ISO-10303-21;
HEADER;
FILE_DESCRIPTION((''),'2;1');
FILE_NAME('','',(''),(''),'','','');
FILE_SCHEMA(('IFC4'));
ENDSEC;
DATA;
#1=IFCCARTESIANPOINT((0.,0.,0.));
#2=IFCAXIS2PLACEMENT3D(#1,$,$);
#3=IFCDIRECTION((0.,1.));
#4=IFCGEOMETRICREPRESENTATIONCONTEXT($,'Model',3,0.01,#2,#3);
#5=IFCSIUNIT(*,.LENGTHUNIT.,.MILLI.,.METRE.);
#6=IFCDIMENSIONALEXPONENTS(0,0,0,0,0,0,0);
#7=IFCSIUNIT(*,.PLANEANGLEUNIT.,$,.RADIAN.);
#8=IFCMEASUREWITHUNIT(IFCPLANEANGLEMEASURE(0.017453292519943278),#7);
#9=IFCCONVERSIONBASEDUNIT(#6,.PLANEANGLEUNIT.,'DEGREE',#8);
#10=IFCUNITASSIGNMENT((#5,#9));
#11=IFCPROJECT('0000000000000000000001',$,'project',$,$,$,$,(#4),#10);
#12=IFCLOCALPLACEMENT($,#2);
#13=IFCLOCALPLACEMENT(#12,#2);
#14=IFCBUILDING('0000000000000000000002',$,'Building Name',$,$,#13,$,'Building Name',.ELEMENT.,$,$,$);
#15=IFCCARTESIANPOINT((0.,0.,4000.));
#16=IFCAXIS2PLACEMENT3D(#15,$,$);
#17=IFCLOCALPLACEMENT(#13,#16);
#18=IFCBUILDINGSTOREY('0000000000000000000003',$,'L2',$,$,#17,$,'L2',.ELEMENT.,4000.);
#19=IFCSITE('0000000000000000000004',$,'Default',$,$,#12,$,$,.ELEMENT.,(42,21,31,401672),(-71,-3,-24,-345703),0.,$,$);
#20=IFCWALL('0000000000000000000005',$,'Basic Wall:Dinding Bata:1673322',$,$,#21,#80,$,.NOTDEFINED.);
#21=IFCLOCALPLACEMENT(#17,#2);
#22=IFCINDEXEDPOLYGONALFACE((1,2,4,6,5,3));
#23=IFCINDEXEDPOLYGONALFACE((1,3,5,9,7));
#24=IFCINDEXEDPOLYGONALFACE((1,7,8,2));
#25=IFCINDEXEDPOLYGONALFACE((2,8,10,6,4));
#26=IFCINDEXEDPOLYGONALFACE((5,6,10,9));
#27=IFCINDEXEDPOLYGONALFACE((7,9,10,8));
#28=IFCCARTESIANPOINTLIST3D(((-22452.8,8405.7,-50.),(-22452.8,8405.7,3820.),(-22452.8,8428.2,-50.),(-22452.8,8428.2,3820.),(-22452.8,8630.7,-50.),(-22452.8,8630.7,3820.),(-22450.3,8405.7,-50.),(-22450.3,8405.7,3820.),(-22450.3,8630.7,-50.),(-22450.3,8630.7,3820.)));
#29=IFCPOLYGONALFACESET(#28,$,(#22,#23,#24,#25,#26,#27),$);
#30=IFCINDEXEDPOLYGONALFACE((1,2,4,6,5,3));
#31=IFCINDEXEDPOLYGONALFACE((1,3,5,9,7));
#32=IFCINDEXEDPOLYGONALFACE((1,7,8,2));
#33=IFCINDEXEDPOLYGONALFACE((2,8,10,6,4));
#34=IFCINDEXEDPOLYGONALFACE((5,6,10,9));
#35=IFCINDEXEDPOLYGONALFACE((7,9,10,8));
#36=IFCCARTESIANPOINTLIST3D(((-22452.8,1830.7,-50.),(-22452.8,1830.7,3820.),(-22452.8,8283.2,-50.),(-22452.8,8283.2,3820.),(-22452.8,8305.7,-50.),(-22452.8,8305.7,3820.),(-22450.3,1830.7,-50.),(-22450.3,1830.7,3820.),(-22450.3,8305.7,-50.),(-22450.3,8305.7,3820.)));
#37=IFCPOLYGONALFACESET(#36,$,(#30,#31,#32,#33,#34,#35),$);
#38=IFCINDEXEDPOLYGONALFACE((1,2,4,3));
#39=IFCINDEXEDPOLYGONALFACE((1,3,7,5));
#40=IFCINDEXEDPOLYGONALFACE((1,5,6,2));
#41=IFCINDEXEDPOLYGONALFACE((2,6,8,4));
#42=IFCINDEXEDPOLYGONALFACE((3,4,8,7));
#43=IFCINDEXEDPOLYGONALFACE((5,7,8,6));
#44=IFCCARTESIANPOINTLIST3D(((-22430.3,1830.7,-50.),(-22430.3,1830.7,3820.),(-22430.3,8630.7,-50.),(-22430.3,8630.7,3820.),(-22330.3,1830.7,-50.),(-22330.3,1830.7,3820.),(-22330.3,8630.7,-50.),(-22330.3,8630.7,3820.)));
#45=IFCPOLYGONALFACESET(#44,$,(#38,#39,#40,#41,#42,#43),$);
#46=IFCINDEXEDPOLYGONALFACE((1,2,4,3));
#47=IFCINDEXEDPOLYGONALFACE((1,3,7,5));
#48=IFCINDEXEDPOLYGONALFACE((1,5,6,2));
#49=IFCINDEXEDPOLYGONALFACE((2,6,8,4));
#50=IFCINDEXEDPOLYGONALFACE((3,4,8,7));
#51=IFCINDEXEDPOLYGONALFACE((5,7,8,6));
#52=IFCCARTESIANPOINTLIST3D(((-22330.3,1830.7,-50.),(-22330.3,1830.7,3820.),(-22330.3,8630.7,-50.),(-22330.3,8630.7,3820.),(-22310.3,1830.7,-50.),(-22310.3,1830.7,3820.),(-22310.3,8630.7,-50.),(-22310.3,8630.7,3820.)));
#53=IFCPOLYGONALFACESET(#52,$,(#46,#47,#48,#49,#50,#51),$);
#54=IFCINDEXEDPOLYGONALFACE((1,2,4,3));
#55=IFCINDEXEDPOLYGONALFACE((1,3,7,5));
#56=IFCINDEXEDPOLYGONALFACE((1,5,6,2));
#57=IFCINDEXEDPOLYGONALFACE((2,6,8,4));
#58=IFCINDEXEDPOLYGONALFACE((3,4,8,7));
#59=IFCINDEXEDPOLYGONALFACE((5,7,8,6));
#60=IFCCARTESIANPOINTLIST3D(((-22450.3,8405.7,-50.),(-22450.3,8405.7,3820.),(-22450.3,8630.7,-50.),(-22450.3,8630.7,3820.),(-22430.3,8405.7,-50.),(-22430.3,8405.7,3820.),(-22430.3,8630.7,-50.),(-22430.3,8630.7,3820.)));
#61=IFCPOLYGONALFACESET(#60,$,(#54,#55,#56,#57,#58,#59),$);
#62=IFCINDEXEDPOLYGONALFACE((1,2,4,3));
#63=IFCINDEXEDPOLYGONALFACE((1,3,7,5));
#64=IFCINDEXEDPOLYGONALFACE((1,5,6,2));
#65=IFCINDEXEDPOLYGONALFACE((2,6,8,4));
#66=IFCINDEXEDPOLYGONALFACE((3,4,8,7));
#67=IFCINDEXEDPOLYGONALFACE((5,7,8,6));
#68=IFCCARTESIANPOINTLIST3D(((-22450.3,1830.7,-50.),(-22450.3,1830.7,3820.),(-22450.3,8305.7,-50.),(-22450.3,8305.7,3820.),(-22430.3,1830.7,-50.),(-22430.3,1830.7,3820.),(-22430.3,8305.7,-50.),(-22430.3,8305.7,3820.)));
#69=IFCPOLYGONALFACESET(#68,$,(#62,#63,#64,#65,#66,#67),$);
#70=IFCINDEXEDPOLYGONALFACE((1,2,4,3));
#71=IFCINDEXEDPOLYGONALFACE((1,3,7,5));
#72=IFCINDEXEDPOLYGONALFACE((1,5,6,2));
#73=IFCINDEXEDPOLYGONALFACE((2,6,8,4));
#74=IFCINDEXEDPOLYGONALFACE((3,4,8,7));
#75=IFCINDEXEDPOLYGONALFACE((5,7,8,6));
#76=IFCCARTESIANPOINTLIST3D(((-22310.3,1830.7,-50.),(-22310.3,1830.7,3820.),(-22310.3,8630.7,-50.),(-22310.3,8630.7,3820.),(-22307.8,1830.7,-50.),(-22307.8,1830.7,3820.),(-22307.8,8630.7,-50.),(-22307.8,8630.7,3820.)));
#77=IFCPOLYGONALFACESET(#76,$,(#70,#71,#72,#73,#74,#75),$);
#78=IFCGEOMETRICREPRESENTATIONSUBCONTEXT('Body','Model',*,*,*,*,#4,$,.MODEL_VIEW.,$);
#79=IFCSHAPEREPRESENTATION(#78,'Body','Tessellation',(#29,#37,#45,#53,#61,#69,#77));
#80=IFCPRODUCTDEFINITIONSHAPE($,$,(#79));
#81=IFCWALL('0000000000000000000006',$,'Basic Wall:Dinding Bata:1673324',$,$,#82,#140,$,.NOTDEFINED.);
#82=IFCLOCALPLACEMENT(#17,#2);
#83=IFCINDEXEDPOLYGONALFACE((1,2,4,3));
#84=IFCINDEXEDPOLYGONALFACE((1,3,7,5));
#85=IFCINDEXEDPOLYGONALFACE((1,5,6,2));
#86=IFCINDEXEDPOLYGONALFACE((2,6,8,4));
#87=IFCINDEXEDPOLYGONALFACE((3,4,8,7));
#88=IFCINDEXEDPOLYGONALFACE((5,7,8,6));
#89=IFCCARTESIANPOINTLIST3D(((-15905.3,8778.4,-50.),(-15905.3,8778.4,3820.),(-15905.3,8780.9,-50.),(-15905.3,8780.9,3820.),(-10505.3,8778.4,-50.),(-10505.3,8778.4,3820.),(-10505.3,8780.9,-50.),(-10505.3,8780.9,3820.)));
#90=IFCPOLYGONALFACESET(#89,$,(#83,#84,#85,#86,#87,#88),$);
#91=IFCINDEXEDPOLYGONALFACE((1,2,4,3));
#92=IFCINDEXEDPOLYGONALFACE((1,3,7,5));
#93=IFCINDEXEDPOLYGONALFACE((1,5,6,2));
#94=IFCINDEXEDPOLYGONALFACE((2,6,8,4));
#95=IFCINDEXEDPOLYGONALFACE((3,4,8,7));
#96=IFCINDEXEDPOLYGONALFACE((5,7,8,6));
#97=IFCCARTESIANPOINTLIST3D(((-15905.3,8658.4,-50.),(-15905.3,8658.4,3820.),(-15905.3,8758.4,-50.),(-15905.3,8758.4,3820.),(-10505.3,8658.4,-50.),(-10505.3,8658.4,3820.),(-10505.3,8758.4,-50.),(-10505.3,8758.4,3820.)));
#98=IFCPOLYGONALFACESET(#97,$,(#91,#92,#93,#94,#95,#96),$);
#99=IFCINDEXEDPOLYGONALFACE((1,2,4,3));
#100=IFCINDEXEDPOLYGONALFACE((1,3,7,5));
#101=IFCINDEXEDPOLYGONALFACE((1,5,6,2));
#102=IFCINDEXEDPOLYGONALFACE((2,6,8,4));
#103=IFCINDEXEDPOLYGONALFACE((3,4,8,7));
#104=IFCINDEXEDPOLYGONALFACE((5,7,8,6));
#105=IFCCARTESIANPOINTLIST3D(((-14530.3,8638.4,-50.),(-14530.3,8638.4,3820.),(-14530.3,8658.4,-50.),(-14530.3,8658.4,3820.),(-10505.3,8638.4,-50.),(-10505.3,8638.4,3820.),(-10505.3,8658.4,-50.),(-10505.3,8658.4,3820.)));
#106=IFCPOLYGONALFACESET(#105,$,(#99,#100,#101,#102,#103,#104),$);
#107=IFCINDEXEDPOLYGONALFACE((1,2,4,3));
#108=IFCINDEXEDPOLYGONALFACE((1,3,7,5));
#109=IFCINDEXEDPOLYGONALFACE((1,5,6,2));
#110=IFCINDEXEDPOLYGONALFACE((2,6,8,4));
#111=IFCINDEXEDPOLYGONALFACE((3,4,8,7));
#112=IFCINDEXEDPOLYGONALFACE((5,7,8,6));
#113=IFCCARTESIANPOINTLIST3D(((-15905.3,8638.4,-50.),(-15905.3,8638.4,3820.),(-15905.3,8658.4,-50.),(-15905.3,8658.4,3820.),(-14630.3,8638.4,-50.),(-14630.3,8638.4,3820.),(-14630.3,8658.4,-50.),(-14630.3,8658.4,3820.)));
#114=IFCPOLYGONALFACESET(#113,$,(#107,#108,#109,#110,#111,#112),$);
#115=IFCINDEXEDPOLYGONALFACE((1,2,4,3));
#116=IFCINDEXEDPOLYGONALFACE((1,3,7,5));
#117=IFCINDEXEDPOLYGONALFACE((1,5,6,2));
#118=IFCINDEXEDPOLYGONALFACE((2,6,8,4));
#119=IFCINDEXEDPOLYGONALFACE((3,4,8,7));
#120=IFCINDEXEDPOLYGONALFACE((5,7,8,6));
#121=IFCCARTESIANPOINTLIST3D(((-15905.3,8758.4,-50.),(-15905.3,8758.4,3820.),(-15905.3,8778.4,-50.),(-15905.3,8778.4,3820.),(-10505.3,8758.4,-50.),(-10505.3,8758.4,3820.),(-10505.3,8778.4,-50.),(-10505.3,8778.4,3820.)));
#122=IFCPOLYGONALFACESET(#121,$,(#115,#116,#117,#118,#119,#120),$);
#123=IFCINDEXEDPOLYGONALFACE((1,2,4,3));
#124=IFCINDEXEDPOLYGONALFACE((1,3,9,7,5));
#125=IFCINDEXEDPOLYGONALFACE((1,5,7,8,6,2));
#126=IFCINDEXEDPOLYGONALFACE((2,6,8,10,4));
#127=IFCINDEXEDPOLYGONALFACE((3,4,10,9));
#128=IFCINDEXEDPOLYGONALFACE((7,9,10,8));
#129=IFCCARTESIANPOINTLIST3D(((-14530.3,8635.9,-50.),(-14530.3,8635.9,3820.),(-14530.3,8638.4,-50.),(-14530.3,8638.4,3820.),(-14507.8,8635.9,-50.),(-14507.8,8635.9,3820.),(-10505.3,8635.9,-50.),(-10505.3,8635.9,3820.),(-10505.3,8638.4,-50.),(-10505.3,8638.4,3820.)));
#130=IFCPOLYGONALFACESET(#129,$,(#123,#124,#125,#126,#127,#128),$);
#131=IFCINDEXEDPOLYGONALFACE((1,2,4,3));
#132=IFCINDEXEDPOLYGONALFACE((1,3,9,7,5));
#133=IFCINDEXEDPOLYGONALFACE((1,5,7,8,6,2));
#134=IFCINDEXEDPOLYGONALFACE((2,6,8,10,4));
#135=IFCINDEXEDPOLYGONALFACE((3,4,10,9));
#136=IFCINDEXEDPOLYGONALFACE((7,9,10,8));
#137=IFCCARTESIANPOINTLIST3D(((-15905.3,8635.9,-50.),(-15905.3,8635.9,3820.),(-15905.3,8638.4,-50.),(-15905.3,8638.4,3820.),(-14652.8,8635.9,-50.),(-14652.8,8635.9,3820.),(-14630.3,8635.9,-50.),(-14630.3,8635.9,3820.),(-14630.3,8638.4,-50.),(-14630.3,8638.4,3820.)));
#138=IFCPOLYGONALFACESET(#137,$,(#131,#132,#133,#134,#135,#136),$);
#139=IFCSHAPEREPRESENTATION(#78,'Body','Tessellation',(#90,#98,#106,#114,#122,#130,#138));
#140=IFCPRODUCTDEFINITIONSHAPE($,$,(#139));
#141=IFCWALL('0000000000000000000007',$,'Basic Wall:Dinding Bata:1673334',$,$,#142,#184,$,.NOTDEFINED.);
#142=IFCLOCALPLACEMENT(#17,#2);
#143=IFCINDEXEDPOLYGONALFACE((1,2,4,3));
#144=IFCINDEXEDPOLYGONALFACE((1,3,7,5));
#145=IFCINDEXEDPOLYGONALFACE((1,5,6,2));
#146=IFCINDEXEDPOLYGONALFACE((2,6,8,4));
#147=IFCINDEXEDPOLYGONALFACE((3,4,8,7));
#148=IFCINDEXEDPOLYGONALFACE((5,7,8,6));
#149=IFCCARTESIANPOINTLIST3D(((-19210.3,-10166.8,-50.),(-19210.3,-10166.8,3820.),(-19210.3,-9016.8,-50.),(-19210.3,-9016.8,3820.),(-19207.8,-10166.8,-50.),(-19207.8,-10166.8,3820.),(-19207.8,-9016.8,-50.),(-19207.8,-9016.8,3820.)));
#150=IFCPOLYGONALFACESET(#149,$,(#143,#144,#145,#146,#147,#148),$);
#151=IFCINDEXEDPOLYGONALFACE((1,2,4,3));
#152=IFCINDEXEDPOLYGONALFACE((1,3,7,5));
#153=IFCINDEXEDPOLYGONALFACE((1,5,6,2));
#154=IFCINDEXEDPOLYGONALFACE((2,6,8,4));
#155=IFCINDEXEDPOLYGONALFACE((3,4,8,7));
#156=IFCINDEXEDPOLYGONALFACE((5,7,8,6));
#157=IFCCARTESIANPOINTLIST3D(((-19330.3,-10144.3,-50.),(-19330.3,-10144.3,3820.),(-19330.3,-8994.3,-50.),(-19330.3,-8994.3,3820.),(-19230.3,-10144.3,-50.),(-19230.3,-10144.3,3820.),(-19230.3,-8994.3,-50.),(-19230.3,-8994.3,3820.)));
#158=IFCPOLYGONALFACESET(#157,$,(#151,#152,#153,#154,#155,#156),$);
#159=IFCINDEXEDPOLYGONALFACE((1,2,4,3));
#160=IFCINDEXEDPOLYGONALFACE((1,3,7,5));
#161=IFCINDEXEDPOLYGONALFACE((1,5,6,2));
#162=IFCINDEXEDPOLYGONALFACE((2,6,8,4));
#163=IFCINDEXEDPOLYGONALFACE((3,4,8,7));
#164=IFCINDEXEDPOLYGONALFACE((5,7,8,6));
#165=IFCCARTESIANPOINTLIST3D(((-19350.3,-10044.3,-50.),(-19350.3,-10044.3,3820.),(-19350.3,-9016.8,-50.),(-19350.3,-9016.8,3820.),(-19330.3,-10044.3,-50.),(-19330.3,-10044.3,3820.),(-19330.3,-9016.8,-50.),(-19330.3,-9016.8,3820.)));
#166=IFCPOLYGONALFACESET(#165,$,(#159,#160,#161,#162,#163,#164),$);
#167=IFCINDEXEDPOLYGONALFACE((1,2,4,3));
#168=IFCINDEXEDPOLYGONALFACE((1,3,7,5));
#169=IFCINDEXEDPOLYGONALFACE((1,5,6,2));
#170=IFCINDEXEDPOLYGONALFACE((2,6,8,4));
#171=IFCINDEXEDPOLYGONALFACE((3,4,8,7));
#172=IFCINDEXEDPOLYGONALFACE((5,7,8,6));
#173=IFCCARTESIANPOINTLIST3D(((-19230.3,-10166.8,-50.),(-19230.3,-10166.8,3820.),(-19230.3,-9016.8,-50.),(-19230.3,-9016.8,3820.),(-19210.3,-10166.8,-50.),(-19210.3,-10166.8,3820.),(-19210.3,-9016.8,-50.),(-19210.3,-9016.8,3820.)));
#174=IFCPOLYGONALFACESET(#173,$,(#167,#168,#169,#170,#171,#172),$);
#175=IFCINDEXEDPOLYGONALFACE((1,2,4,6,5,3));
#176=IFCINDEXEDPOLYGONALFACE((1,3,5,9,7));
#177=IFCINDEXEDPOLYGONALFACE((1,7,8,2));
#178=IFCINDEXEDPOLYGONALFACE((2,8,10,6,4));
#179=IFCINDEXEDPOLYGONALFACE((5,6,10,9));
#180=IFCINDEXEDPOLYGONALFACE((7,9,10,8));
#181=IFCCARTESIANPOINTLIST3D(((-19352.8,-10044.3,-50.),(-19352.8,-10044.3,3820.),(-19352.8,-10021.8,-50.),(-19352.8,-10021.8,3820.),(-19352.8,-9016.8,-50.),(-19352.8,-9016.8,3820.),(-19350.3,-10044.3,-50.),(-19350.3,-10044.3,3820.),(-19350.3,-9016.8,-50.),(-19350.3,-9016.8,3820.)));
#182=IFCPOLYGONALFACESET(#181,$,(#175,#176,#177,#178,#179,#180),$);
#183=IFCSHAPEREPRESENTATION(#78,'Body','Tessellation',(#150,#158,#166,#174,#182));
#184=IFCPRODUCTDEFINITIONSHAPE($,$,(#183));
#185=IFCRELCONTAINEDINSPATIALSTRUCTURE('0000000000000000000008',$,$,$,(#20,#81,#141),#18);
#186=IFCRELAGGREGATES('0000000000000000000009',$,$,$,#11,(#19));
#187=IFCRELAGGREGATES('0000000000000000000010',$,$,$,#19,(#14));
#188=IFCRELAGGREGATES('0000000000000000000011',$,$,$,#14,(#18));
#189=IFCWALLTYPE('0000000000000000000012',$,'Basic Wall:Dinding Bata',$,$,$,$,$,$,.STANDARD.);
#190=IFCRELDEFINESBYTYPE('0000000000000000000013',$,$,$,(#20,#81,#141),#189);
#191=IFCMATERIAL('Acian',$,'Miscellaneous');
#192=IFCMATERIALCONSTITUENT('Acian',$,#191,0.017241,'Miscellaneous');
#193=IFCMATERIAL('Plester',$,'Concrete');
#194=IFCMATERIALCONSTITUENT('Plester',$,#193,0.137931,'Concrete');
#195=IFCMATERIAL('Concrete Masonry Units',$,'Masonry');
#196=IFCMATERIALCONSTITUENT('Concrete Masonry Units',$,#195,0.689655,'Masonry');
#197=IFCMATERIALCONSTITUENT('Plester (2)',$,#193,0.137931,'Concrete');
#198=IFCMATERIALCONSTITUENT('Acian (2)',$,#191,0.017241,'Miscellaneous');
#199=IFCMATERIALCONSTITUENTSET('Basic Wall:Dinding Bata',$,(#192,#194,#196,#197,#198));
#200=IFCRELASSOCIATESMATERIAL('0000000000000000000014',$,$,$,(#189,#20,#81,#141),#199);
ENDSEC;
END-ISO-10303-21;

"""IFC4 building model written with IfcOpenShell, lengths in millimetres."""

from ifc_helpers import new_model, entity, si_unit, converted_unit, direction, frame, origin, place, context, subcontext, project, spatial, indexed_curve, outline, extrude, material, constituent, constituent_set, type_object, element, save


model = new_model("IFC4")

# Units and contexts
model_context = context("Model", 3, precision=0.01, world=origin(), true_north=direction((0.0, 1.0)))
body_context = subcontext(model_context, "Body", "Model", "MODEL_VIEW")
ifc_project = project(units=[si_unit("LENGTHUNIT", "METRE", prefix="MILLI"), converted_unit("PLANEANGLEUNIT", "DEGREE", entity("IfcPlaneAngleMeasure", 0.017453292519943278), si_unit("PLANEANGLEUNIT", "RADIAN"), dimensions=[0, 0, 0, 0, 0, 0, 0])], contexts=[model_context])

# Site, building, storey
site_placement = place(None, origin())
site = spatial("IfcSite", under=ifc_project, at=site_placement, Name="Default", CompositionType="ELEMENT", RefLatitude=(42, 21, 31, 401672), RefLongitude=(-71, -3, -24, -345703), RefElevation=0.0)
building_placement = place(site_placement, origin())
building = spatial("IfcBuilding", under=site, at=building_placement, Name="Building Name", LongName="Building Name", CompositionType="ELEMENT")
storey_placement = place(building_placement, frame((0.0, 0.0, 4000.0)))
storey = spatial("IfcBuildingStorey", under=building, at=storey_placement, Name="L2", LongName="L2", CompositionType="ELEMENT", Elevation=4000.0)

# Walls
ifc_material_1 = material(Name="Acian", Category="Miscellaneous")
ifc_constituent_1 = constituent(ifc_material_1, Name="Acian", Category="Miscellaneous", fraction=0.017241)
ifc_material_2 = material(Name="Plester", Category="Concrete")
ifc_constituent_2 = constituent(ifc_material_2, Name="Plester", Category="Concrete", fraction=0.137931)
ifc_material_3 = material(Name="Concrete Masonry Units", Category="Masonry")
ifc_constituent_3 = constituent(ifc_material_3, Name="Concrete Masonry Units", Category="Masonry", fraction=0.689655)
ifc_constituent_4 = constituent(ifc_material_2, Name="Plester (2)", Category="Concrete", fraction=0.137931)
ifc_constituent_5 = constituent(ifc_material_1, Name="Acian (2)", Category="Miscellaneous", fraction=0.017241)
ifc_constituent_set = constituent_set(constituents=[ifc_constituent_1, ifc_constituent_2, ifc_constituent_3, ifc_constituent_4, ifc_constituent_5], Name="Basic Wall:Dinding Bata")
wall_type = type_object("IfcWallType", Name="Basic Wall:Dinding Bata", PredefinedType="STANDARD", material=ifc_constituent_set)
wall_1_placement = place(storey_placement, frame((-22380.3, 1830.7, -50.0), z_axis=(0.0, 0.0, 1.0), x_axis=(0.0, 1.0, 0.0)))
element("IfcWall", 1, at=wall_1_placement, inside=storey, type_object=wall_type, material=ifc_constituent_set, Name="Basic Wall:Dinding Bata:1673322", PredefinedType="NOTDEFINED", context=body_context, shape_type="SweptSolid", body=[
    extrude(outline(indexed_curve([(72.0, -1.0), (94.5, -1.0), (94.5, 1.5), (-130.5, 1.5), (-130.5, -1.0), (72.0, -1.0)], self_intersect=False)), frame((6669.5, 71.5, 0.0), z_axis=(0.0, 0.0, 1.0), x_axis=(-1.0, 0.0, 0.0)), (0.0, 0.0, 1.0), 3870.0),
    extrude(outline(indexed_curve([(-3880.5, -1.5), (2594.5, -1.5), (2594.5, 1.0), (2572.0, 1.0), (-3880.5, 1.0), (-3880.5, -1.5)], self_intersect=False)), frame((3880.5, 71.5, 0.0)), (0.0, 0.0, 1.0), 3870.0),
    extrude(outline(indexed_curve([(-3400.0, -50.0), (3400.0, -50.0), (3400.0, 50.0), (-3400.0, 50.0), (-3400.0, -50.0)], self_intersect=False)), frame((3400.0, 0.0, 0.0)), (0.0, 0.0, 1.0), 3870.0),
    extrude(outline(indexed_curve([(-3400.0, -10.0), (3400.0, -10.0), (3400.0, 10.0), (-3400.0, 10.0), (-3400.0, -10.0)], self_intersect=False)), frame((3400.0, -60.0, 0.0)), (0.0, 0.0, 1.0), 3870.0),
    extrude(outline(indexed_curve([(-112.5, -10.0), (112.5, -10.0), (112.5, 10.0), (-112.5, 10.0), (-112.5, -10.0)], self_intersect=False)), frame((6687.5, 60.0, 0.0), z_axis=(0.0, 0.0, 1.0), x_axis=(-1.0, 0.0, 0.0)), (0.0, 0.0, 1.0), 3870.0),
    extrude(outline(indexed_curve([(-3237.5, -10.0), (3237.5, -10.0), (3237.5, 10.0), (-3237.5, 10.0), (-3237.5, -10.0)], self_intersect=False)), frame((3237.5, 60.0, 0.0)), (0.0, 0.0, 1.0), 3870.0),
    extrude(outline(indexed_curve([(-1.3, -3400.0), (1.2, -3400.0), (1.3, 3400.0), (-1.2, 3400.0), (-1.3, -3400.0)], self_intersect=False)), frame((3400.0, -71.3, 0.0), z_axis=(0.0, 0.0, 1.0), x_axis=(0.0, 1.0, 0.0)), (0.0, 0.0, 1.0), 3870.0),
])
wall_2_placement = place(storey_placement, frame((-15905.3, 8708.4, -50.0)))
element("IfcWall", 2, at=wall_2_placement, inside=storey, type_object=wall_type, material=ifc_constituent_set, Name="Basic Wall:Dinding Bata:1673324", PredefinedType="NOTDEFINED", context=body_context, shape_type="SweptSolid", body=[
    extrude(outline(indexed_curve([(-1.3, -2700.0), (1.2, -2700.0), (1.3, 2700.0), (-1.2, 2700.0), (-1.3, -2700.0)], self_intersect=False)), frame((2700.0, 71.3, 0.0), z_axis=(0.0, 0.0, 1.0), x_axis=(0.0, -1.0, 0.0)), (0.0, 0.0, 1.0), 3870.0),
    extrude(outline(indexed_curve([(-2700.0, -50.0), (2700.0, -50.0), (2700.0, 50.0), (-2700.0, 50.0), (-2700.0, -50.0)], self_intersect=False)), frame((2700.0, 0.0, 0.0)), (0.0, 0.0, 1.0), 3870.0),
    extrude(outline(indexed_curve([(-2012.5, -10.0), (2012.5, -10.0), (2012.5, 10.0), (-2012.5, 10.0), (-2012.5, -10.0)], self_intersect=False)), frame((3387.5, -60.0, 0.0), z_axis=(0.0, 0.0, 1.0), x_axis=(-1.0, 0.0, 0.0)), (0.0, 0.0, 1.0), 3870.0),
    extrude(outline(indexed_curve([(-637.5, -10.0), (637.5, -10.0), (637.5, 10.0), (-637.5, 10.0), (-637.5, -10.0)], self_intersect=False)), frame((637.5, -60.0, 0.0)), (0.0, 0.0, 1.0), 3870.0),
    extrude(outline(indexed_curve([(-2700.0, -10.0), (2700.0, -10.0), (2700.0, 10.0), (-2700.0, 10.0), (-2700.0, -10.0)], self_intersect=False)), frame((2700.0, 60.0, 0.0)), (0.0, 0.0, 1.0), 3870.0),
    extrude(outline(indexed_curve([(-1.0, -2410.5), (1.5, -2410.5), (1.5, 1614.5), (-1.0, 1614.5), (-1.0, 1592.0), (-1.0, -2410.5)], self_intersect=False)), frame((2989.5, -71.5, 0.0), z_axis=(0.0, 0.0, 1.0), x_axis=(0.0, 1.0, 0.0)), (0.0, 0.0, 1.0), 3870.0),
    extrude(outline(indexed_curve([(492.0, -1.0), (514.5, -1.0), (514.5, 1.5), (-760.5, 1.5), (-760.5, -1.0), (492.0, -1.0)], self_intersect=False)), frame((760.5, -71.5, 0.0)), (0.0, 0.0, 1.0), 3870.0),
])
wall_3_placement = place(storey_placement, frame((-19280.3, -9016.8, -50.0), z_axis=(0.0, 0.0, 1.0), x_axis=(0.0, -1.0, 0.0)))
element("IfcWall", 3, at=wall_3_placement, inside=storey, type_object=wall_type, material=ifc_constituent_set, Name="Basic Wall:Dinding Bata:1673334", PredefinedType="NOTDEFINED", context=body_context, shape_type="SweptSolid", body=[
    extrude(outline(indexed_curve([(-1.3, -575.0), (1.2, -575.0), (1.3, 575.0), (-1.2, 575.0), (-1.3, -575.0)], self_intersect=False)), frame((575.0, 71.2, 0.0), z_axis=(0.0, 0.0, 1.0), x_axis=(0.0, -1.0, 0.0)), (0.0, 0.0, 1.0), 3870.0),
    extrude(outline(indexed_curve([(-575.0, -50.0), (575.0, -50.0), (575.0, 50.0), (-575.0, 50.0), (-575.0, -50.0)], self_intersect=False)), frame((552.5, 0.0, 0.0)), (0.0, 0.0, 1.0), 3870.0),
    extrude(outline(indexed_curve([(-513.7, -10.0), (513.7, -10.0), (513.7, 10.0), (-513.7, 10.0), (-513.7, -10.0)], self_intersect=False)), frame((513.7, -60.0, 0.0)), (0.0, 0.0, 1.0), 3870.0),
    extrude(outline(indexed_curve([(-575.0, -10.0), (575.0, -10.0), (575.0, 10.0), (-575.0, 10.0), (-575.0, -10.0)], self_intersect=False)), frame((575.0, 60.0, 0.0)), (0.0, 0.0, 1.0), 3870.0),
    extrude(outline(indexed_curve([(393.0, -1.0), (415.5, -1.0), (415.5, 1.5), (-612.0, 1.5), (-612.0, -1.0), (393.0, -1.0)], self_intersect=False)), frame((612.0, -71.5, 0.0)), (0.0, 0.0, 1.0), 3870.0),
])

save(model, "model.ifc")
